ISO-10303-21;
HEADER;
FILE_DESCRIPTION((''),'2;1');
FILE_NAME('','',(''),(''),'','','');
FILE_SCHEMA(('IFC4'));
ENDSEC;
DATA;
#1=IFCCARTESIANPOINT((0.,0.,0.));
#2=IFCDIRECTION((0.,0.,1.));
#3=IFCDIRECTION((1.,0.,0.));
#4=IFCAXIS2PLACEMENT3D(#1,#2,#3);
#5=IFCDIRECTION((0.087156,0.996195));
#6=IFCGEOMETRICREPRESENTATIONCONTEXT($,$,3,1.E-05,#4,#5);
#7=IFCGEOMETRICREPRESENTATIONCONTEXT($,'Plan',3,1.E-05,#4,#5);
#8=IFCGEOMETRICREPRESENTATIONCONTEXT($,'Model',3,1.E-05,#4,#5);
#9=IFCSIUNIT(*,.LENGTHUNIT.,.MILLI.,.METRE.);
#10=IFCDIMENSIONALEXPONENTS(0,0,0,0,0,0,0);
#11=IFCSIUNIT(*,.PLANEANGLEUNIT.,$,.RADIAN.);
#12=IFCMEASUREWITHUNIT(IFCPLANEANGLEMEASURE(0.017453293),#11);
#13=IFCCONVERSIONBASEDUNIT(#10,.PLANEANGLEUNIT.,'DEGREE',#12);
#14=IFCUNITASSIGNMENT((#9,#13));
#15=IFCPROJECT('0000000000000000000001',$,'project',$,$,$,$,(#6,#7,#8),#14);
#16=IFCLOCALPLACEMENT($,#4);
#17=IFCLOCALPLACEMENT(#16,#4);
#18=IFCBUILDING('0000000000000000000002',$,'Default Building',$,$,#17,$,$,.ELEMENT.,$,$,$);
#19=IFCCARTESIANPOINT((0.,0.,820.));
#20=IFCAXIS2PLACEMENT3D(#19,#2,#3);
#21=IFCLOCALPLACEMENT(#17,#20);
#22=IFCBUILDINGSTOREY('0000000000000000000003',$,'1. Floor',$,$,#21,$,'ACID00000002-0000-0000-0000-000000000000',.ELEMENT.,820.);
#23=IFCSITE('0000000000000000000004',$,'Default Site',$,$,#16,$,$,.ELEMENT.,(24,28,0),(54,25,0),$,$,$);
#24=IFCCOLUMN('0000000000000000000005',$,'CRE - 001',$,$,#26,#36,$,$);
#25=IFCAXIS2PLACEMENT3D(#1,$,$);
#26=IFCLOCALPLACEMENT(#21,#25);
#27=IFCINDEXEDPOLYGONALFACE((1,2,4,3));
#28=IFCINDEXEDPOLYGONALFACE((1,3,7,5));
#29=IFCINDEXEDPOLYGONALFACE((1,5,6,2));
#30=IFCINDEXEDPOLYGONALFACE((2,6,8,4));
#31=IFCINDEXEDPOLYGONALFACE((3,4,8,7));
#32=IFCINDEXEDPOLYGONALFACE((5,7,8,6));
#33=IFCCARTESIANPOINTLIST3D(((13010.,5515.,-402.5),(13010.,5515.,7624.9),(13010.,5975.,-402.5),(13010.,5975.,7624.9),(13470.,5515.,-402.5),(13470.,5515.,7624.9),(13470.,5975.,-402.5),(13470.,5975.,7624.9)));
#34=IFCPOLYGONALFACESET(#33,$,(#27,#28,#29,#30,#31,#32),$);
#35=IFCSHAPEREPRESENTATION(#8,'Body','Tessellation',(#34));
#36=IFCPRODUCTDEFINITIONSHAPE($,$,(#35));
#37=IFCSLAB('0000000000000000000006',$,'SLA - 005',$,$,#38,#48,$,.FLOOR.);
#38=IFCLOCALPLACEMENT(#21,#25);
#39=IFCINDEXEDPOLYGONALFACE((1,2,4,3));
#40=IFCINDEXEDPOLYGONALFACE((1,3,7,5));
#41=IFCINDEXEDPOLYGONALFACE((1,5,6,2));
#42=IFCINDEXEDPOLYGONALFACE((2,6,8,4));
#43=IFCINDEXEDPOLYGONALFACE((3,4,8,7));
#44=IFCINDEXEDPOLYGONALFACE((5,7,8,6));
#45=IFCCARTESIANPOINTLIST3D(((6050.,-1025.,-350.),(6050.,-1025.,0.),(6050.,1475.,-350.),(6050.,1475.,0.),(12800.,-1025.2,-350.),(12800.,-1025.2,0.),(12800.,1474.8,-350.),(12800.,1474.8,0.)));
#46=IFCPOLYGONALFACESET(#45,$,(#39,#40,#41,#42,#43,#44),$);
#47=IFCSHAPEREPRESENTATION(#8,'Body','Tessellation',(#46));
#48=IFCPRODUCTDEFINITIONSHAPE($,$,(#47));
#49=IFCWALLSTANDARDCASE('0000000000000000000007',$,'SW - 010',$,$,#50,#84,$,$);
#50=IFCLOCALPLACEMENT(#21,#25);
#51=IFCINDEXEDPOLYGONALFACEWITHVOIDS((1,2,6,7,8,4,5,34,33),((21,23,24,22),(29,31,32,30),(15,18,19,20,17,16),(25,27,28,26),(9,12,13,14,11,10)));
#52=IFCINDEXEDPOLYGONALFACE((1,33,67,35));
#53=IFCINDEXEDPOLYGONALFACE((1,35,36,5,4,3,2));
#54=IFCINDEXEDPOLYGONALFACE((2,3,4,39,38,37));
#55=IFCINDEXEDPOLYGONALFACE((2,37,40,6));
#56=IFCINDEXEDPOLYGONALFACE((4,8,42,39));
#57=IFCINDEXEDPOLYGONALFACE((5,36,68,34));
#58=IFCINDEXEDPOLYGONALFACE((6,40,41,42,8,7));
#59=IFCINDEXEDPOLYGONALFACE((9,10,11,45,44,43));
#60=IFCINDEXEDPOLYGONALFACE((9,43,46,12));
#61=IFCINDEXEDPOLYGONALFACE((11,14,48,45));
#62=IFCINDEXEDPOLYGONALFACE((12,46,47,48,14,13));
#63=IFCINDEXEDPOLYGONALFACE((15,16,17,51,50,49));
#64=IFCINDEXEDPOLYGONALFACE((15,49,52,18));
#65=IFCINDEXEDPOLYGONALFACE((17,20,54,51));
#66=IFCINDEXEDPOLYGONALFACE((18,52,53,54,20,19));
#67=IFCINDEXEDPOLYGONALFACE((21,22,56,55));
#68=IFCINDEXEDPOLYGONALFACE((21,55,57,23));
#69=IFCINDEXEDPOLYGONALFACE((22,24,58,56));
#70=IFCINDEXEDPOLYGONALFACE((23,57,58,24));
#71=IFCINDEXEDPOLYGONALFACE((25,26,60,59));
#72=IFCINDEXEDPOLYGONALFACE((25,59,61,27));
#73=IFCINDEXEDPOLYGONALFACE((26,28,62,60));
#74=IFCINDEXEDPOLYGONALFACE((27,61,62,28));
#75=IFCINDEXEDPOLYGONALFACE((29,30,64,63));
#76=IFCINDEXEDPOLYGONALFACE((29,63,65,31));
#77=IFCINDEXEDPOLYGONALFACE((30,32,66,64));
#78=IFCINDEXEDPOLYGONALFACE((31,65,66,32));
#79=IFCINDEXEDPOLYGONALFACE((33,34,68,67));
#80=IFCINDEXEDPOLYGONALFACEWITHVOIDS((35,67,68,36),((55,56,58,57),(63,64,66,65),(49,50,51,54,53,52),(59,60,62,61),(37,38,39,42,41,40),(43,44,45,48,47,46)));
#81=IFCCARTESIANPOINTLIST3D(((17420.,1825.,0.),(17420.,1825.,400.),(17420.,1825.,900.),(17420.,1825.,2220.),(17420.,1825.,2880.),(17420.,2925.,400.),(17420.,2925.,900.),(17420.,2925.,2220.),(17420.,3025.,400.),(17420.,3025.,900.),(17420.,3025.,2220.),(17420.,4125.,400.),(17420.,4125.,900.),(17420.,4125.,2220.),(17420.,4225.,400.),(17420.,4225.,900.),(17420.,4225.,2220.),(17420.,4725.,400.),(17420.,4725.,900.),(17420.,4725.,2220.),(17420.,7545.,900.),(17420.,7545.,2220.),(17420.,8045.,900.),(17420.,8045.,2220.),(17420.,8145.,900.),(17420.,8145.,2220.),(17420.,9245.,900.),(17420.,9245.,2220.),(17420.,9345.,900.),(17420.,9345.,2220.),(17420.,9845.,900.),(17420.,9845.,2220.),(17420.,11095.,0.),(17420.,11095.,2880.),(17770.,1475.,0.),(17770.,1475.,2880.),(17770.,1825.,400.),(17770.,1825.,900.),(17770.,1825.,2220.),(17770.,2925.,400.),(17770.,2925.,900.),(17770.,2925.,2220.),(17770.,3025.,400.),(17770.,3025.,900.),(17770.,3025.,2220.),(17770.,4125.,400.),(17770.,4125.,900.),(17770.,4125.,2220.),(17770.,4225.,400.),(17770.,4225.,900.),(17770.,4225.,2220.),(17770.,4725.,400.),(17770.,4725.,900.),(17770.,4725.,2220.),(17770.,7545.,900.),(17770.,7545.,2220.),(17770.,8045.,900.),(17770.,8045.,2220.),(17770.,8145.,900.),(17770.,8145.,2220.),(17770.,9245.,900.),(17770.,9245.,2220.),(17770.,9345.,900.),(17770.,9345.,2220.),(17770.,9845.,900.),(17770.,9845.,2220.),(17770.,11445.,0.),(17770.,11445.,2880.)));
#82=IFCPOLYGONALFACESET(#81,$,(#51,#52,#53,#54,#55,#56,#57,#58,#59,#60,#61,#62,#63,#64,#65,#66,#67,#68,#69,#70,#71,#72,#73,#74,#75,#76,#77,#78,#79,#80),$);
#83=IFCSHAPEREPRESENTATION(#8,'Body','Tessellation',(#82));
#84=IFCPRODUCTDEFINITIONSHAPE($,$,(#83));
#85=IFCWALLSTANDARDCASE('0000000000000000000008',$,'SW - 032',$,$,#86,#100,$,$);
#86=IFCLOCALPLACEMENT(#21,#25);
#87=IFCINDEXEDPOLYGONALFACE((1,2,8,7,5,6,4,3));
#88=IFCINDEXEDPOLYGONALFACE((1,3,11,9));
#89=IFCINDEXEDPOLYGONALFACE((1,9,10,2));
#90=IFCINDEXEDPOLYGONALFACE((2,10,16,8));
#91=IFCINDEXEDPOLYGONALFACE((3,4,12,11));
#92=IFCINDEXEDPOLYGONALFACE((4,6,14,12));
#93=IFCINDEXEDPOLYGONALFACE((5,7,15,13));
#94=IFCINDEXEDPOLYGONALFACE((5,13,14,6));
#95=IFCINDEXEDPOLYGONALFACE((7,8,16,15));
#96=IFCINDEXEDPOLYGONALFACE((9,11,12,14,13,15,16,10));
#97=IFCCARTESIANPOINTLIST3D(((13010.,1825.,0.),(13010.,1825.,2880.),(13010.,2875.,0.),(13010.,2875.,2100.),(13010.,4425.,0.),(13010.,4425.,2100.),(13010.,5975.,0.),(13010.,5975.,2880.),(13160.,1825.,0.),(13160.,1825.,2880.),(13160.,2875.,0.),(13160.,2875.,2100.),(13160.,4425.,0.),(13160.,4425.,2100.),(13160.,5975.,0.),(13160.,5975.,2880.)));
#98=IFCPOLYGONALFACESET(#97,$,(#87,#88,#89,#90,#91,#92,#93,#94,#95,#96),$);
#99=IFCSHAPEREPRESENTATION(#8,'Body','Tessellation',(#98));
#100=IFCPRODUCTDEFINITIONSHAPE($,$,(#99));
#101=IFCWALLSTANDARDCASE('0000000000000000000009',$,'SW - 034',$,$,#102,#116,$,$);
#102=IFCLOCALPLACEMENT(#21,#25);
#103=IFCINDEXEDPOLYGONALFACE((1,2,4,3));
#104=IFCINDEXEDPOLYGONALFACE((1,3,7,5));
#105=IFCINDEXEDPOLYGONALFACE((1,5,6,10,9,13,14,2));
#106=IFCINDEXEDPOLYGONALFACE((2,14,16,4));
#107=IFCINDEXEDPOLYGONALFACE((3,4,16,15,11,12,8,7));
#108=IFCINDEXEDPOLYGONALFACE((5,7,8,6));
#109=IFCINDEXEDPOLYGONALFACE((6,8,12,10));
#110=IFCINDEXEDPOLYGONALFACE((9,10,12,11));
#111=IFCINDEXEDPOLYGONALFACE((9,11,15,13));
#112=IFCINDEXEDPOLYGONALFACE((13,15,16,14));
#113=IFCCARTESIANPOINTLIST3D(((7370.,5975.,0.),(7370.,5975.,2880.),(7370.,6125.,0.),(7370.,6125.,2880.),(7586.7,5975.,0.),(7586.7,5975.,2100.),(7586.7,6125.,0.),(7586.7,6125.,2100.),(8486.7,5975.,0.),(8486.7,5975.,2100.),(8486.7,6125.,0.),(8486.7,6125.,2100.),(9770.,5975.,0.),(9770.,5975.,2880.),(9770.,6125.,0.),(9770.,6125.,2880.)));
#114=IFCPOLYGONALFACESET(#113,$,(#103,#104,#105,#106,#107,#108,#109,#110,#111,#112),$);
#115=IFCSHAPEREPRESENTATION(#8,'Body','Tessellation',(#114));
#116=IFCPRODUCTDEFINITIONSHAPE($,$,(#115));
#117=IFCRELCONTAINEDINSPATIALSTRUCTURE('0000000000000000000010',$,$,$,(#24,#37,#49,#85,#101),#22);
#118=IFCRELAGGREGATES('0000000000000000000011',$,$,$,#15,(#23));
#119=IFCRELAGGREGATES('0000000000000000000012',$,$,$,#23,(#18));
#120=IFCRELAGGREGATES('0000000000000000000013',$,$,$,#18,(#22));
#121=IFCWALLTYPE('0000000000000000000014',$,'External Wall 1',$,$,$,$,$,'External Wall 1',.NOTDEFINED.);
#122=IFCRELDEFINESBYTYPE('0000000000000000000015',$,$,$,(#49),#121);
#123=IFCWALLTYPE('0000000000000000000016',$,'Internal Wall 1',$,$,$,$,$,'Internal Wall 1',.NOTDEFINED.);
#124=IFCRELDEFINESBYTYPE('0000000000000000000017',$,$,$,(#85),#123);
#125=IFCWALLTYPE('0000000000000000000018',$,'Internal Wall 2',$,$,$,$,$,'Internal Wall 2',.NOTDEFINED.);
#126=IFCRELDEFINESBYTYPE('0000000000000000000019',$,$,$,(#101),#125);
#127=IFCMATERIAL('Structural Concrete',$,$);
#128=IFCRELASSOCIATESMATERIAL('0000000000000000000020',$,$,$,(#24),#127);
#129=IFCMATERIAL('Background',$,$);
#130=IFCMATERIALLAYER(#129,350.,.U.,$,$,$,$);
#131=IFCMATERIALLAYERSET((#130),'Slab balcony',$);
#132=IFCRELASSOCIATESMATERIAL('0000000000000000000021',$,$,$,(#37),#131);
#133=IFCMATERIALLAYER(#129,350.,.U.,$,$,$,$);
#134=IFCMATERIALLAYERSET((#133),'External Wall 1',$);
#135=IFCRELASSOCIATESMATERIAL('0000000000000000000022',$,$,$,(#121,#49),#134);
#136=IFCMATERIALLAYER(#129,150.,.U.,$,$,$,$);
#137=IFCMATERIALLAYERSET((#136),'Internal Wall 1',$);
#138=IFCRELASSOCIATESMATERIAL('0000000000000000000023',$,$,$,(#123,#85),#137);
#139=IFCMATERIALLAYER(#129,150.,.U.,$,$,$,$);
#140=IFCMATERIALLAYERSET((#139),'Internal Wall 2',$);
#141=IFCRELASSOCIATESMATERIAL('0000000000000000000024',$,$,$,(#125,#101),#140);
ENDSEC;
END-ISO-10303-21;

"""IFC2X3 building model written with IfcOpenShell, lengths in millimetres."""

from ifc_helpers import new_model, entity, si_unit, converted_unit, direction, frame, frame_2d, origin_with_axes, origin_2d_with_axis, place, context, project, spatial, polyline, rectangle, outline, extrude, material, layer, layer_set, layer_usage, type_object, element, save


model = new_model("IFC2X3")

# Units and contexts
context_of_model = context(None, 3, precision=1e-05, world=origin_with_axes(), true_north=direction((0.087156, 0.996195)))
plan_context = context("Plan", 3, precision=1e-05, world=origin_with_axes(), true_north=direction((0.087156, 0.996195)))
model_context = context("Model", 3, precision=1e-05, world=origin_with_axes(), true_north=direction((0.087156, 0.996195)))
ifc_project = project(units=[si_unit("LENGTHUNIT", "METRE", prefix="MILLI"), converted_unit("PLANEANGLEUNIT", "DEGREE", entity("IfcPlaneAngleMeasure", 0.017453293), si_unit("PLANEANGLEUNIT", "RADIAN"), dimensions=[0, 0, 0, 0, 0, 0, 0])], contexts=[context_of_model, plan_context, model_context])

# Site, building, storey
site_placement = place(None, origin_with_axes())
site = spatial("IfcSite", under=ifc_project, at=site_placement, Name="Default Site", CompositionType="ELEMENT", RefLatitude=(24, 28, 0), RefLongitude=(54, 25, 0))
building_placement = place(site_placement, origin_with_axes())
building = spatial("IfcBuilding", under=site, at=building_placement, Name="Default Building", CompositionType="ELEMENT")
storey_placement = place(building_placement, frame((0.0, 0.0, 820.0), z_axis=(0.0, 0.0, 1.0), x_axis=(1.0, 0.0, 0.0)))
storey = spatial("IfcBuildingStorey", under=building, at=storey_placement, Name="1. Floor", LongName="ACID00000002-0000-0000-0000-000000000000", CompositionType="ELEMENT", Elevation=820.0)

# Column
ifc_material_1 = material(Name="Structural Concrete")
column_placement = place(storey_placement, frame((13240.0, 5745.0, -402.5), z_axis=(0.0, 0.0, 1.0), x_axis=(-1.0, 0.0, 0.0)))
element("IfcColumn", 1, at=column_placement, inside=storey, material=ifc_material_1, Name="CRE - 001", context=model_context, shape_type="SweptSolid", body=[
    extrude(rectangle(XDim=460.0, YDim=460.0, at=origin_2d_with_axis()), origin_with_axes(), (0.0, 0.0, 1.0), 8027.4),
])

# Slab
ifc_material_2 = material(Name="Background")
ifc_layer_1 = layer(ifc_material_2, 350.0, ventilated="UNKNOWN")
ifc_layer_set_1 = layer_set([ifc_layer_1], Name="Slab balcony")
ifc_layer_usage_1 = layer_usage(ifc_layer_set_1, "AXIS3", "NEGATIVE", 350.0)
slab_placement = place(storey_placement, frame((12800.0, 1474.8, -350.0), z_axis=(0.0, 0.0, 1.0), x_axis=(0.0, -1.0, 0.0)))
element("IfcSlab", 2, at=slab_placement, inside=storey, material=ifc_layer_usage_1, Name="SLA - 005", PredefinedType="FLOOR", context=model_context, shape_type="SweptSolid", body=[
    extrude(outline(polyline([(0.0, 0.0), (2500.0, 0.0), (2499.8, -6750.0), (-0.2, -6750.0), (0.0, 0.0)])), origin_with_axes(), (0.0, 0.0, 1.0), 350.0),
])

# Wall, openings
ifc_layer_2 = layer(ifc_material_2, 350.0, ventilated="UNKNOWN")
ifc_layer_set_2 = layer_set([ifc_layer_2], Name="External Wall 1")
ifc_layer_usage_2 = layer_usage(ifc_layer_set_2, "AXIS2", "POSITIVE", 0.0)
wall_type_1 = type_object("IfcWallType", Name="External Wall 1", ElementType="External Wall 1", PredefinedType="NOTDEFINED", material=ifc_layer_set_2)
wall_1_placement = place(storey_placement, frame((17770.0, 1475.0, 0.0), z_axis=(0.0, 0.0, 1.0), x_axis=(0.0, 1.0, 0.0)))
wall_1 = element("IfcWallStandardCase", 3, at=wall_1_placement, inside=storey, type_object=wall_type_1, material=ifc_layer_usage_2, Name="SW - 010", context=model_context, shape_type="SweptSolid", body=[
    extrude(outline(polyline([(0.0, 0.0), (9970.0, 0.0), (9620.0, 350.0), (350.0, 350.0), (0.0, 0.0)])), origin_with_axes(), (0.0, 0.0, 1.0), 2880.0),
])
opening_1_placement = place(wall_1_placement, frame((8120.0, 0.0, 900.0), z_axis=(0.0, 0.0, 1.0), x_axis=(1.0, 0.0, 0.0)))
element("IfcOpeningElement", 4, at=opening_1_placement, cuts=wall_1, ObjectType="Opening", context=model_context, shape_type="SweptSolid", body=[
    extrude(rectangle(XDim=500.0, YDim=1320.0, at=frame_2d((0.0, 660.0), x_axis=(1.0, 0.0))), frame((0.0, 0.0, 0.0), z_axis=(0.0, 1.0, 0.0), x_axis=(-1.0, 0.0, 0.0)), (0.0, 0.0, 1.0), 350.0),
])
opening_2_placement = place(wall_1_placement, frame((7220.0, 0.0, 900.0), z_axis=(0.0, 0.0, 1.0), x_axis=(1.0, 0.0, 0.0)))
element("IfcOpeningElement", 5, at=opening_2_placement, cuts=wall_1, ObjectType="Opening", context=model_context, shape_type="SweptSolid", body=[
    extrude(rectangle(XDim=1100.0, YDim=1320.0, at=frame_2d((0.0, 660.0), x_axis=(1.0, 0.0))), frame((0.0, 0.0, 0.0), z_axis=(0.0, 1.0, 0.0), x_axis=(-1.0, 0.0, 0.0)), (0.0, 0.0, 1.0), 350.0),
])
opening_3_placement = place(wall_1_placement, frame((6320.0, 0.0, 900.0), z_axis=(0.0, 0.0, 1.0), x_axis=(1.0, 0.0, 0.0)))
element("IfcOpeningElement", 6, at=opening_3_placement, cuts=wall_1, ObjectType="Opening", context=model_context, shape_type="SweptSolid", body=[
    extrude(rectangle(XDim=500.0, YDim=1320.0, at=frame_2d((0.0, 660.0), x_axis=(1.0, 0.0))), frame((0.0, 0.0, 0.0), z_axis=(0.0, 1.0, 0.0), x_axis=(-1.0, 0.0, 0.0)), (0.0, 0.0, 1.0), 350.0),
])
opening_4_placement = place(wall_1_placement, frame((900.0, 0.0, 900.0), z_axis=(0.0, 0.0, 1.0), x_axis=(1.0, 0.0, 0.0)))
element("IfcOpeningElement", 7, at=opening_4_placement, cuts=wall_1, ObjectType="Opening", context=model_context, shape_type="SweptSolid", body=[
    extrude(outline(polyline([(-550.0, 0.0), (550.0, 0.0), (550.0, 1320.0), (-550.0, 1320.0), (-550.0, 0.0)])), frame((0.0, 0.0, 0.0), z_axis=(0.0, 1.0, 0.0), x_axis=(-1.0, 0.0, 0.0)), (0.0, 0.0, 1.0), 350.0),
])
opening_5_placement = place(wall_1_placement, frame((2100.0, 0.0, 900.0), z_axis=(0.0, 0.0, 1.0), x_axis=(1.0, 0.0, 0.0)))
element("IfcOpeningElement", 8, at=opening_5_placement, cuts=wall_1, ObjectType="Opening", context=model_context, shape_type="SweptSolid", body=[
    extrude(outline(polyline([(-550.0, 0.0), (550.0, 0.0), (550.0, 1320.0), (-550.0, 1320.0), (-550.0, 0.0)])), frame((0.0, 0.0, 0.0), z_axis=(0.0, 1.0, 0.0), x_axis=(-1.0, 0.0, 0.0)), (0.0, 0.0, 1.0), 350.0),
])
opening_6_placement = place(wall_1_placement, frame((3000.0, 0.0, 900.0), z_axis=(0.0, 0.0, 1.0), x_axis=(1.0, 0.0, 0.0)))
element("IfcOpeningElement", 9, at=opening_6_placement, cuts=wall_1, ObjectType="Opening", context=model_context, shape_type="SweptSolid", body=[
    extrude(outline(polyline([(-250.0, 0.0), (250.0, 0.0), (250.0, 1320.0), (-250.0, 1320.0), (-250.0, 0.0)])), frame((0.0, 0.0, 0.0), z_axis=(0.0, 1.0, 0.0), x_axis=(-1.0, 0.0, 0.0)), (0.0, 0.0, 1.0), 350.0),
])
opening_7_placement = place(wall_1_placement, frame((3000.0, 0.0, 400.0), z_axis=(0.0, 0.0, 1.0), x_axis=(1.0, 0.0, 0.0)))
element("IfcOpeningElement", 10, at=opening_7_placement, cuts=wall_1, ObjectType="Opening", context=model_context, shape_type="SweptSolid", body=[
    extrude(outline(polyline([(-250.0, 0.0), (250.0, 0.0), (250.0, 500.0), (-250.0, 500.0), (-250.0, 0.0)])), frame((0.0, 0.0, 0.0), z_axis=(0.0, 1.0, 0.0), x_axis=(-1.0, 0.0, 0.0)), (0.0, 0.0, 1.0), 350.0),
])
opening_8_placement = place(wall_1_placement, frame((2100.0, 0.0, 400.0), z_axis=(0.0, 0.0, 1.0), x_axis=(1.0, 0.0, 0.0)))
element("IfcOpeningElement", 11, at=opening_8_placement, cuts=wall_1, ObjectType="Opening", context=model_context, shape_type="SweptSolid", body=[
    extrude(outline(polyline([(-550.0, 0.0), (550.0, 0.0), (550.0, 500.0), (-550.0, 500.0), (-550.0, 0.0)])), frame((0.0, 0.0, 0.0), z_axis=(0.0, 1.0, 0.0), x_axis=(-1.0, 0.0, 0.0)), (0.0, 0.0, 1.0), 350.0),
])
opening_9_placement = place(wall_1_placement, frame((900.0, 0.0, 400.0), z_axis=(0.0, 0.0, 1.0), x_axis=(1.0, 0.0, 0.0)))
element("IfcOpeningElement", 12, at=opening_9_placement, cuts=wall_1, ObjectType="Opening", context=model_context, shape_type="SweptSolid", body=[
    extrude(outline(polyline([(-550.0, 0.0), (550.0, 0.0), (550.0, 500.0), (-550.0, 500.0), (-550.0, 0.0)])), frame((0.0, 0.0, 0.0), z_axis=(0.0, 1.0, 0.0), x_axis=(-1.0, 0.0, 0.0)), (0.0, 0.0, 1.0), 350.0),
])
ifc_layer_3 = layer(ifc_material_2, 150.0, ventilated="UNKNOWN")
ifc_layer_set_3 = layer_set([ifc_layer_3], Name="Internal Wall 1")
wall_type_2 = type_object("IfcWallType", Name="Internal Wall 1", ElementType="Internal Wall 1", PredefinedType="NOTDEFINED", material=ifc_layer_set_3)

# Wall, opening
ifc_layer_usage_3 = layer_usage(ifc_layer_set_3, "AXIS2", "POSITIVE", 0.0)
wall_2_placement = place(storey_placement, frame((13010.0, 5975.0, 0.0), z_axis=(0.0, 0.0, 1.0), x_axis=(0.0, -1.0, 0.0)))
wall_2 = element("IfcWallStandardCase", 13, at=wall_2_placement, inside=storey, type_object=wall_type_2, material=ifc_layer_usage_3, Name="SW - 032", context=model_context, shape_type="SweptSolid", body=[
    extrude(outline(polyline([(0.0, 0.0), (4150.0, 0.0), (4150.0, 150.0), (0.0, 150.0), (0.0, 0.0)])), origin_with_axes(), (0.0, 0.0, 1.0), 2880.0),
])
opening_10_placement = place(wall_2_placement, frame((2325.0, 0.0, 0.0), z_axis=(0.0, 0.0, 1.0), x_axis=(1.0, 0.0, 0.0)))
element("IfcOpeningElement", 14, at=opening_10_placement, cuts=wall_2, ObjectType="Opening", context=model_context, shape_type="SweptSolid", body=[
    extrude(rectangle(XDim=1550.0, YDim=2100.0, at=frame_2d((0.0, 1050.0), x_axis=(-1.0, 0.0))), frame((0.0, 0.0, 0.0), z_axis=(0.0, 1.0, 0.0), x_axis=(-1.0, 0.0, 0.0)), (0.0, 0.0, 1.0), 150.0),
])

# Shared definitions
ifc_layer_4 = layer(ifc_material_2, 150.0, ventilated="UNKNOWN")
ifc_layer_set_4 = layer_set([ifc_layer_4], Name="Internal Wall 2")
wall_type_3 = type_object("IfcWallType", Name="Internal Wall 2", ElementType="Internal Wall 2", PredefinedType="NOTDEFINED", material=ifc_layer_set_4)

# Wall, opening
ifc_layer_usage_4 = layer_usage(ifc_layer_set_4, "AXIS2", "NEGATIVE", 0.0)
wall_3_placement = place(storey_placement, frame((9770.0, 5975.0, 0.0), z_axis=(0.0, 0.0, 1.0), x_axis=(-1.0, 0.0, 0.0)))
wall_3 = element("IfcWallStandardCase", 15, at=wall_3_placement, inside=storey, type_object=wall_type_3, material=ifc_layer_usage_4, Name="SW - 034", context=model_context, shape_type="SweptSolid", body=[
    extrude(outline(polyline([(0.0, -150.0), (2400.0, -150.0), (2400.0, 0.0), (0.0, 0.0), (0.0, -150.0)])), origin_with_axes(), (0.0, 0.0, 1.0), 2880.0),
])
opening_11_placement = place(wall_3_placement, frame((1733.3, -150.0, 0.0), z_axis=(0.0, 0.0, 1.0), x_axis=(1.0, 0.0, 0.0)))
element("IfcOpeningElement", 16, at=opening_11_placement, cuts=wall_3, ObjectType="Opening", context=model_context, shape_type="SweptSolid", body=[
    extrude(rectangle(XDim=900.0, YDim=2100.0, at=frame_2d((0.0, 1050.0), x_axis=(-1.0, 0.0))), frame((0.0, 0.0, 0.0), z_axis=(0.0, 1.0, 0.0), x_axis=(-1.0, 0.0, 0.0)), (0.0, 0.0, 1.0), 150.0),
])

save(model, "model.ifc")
